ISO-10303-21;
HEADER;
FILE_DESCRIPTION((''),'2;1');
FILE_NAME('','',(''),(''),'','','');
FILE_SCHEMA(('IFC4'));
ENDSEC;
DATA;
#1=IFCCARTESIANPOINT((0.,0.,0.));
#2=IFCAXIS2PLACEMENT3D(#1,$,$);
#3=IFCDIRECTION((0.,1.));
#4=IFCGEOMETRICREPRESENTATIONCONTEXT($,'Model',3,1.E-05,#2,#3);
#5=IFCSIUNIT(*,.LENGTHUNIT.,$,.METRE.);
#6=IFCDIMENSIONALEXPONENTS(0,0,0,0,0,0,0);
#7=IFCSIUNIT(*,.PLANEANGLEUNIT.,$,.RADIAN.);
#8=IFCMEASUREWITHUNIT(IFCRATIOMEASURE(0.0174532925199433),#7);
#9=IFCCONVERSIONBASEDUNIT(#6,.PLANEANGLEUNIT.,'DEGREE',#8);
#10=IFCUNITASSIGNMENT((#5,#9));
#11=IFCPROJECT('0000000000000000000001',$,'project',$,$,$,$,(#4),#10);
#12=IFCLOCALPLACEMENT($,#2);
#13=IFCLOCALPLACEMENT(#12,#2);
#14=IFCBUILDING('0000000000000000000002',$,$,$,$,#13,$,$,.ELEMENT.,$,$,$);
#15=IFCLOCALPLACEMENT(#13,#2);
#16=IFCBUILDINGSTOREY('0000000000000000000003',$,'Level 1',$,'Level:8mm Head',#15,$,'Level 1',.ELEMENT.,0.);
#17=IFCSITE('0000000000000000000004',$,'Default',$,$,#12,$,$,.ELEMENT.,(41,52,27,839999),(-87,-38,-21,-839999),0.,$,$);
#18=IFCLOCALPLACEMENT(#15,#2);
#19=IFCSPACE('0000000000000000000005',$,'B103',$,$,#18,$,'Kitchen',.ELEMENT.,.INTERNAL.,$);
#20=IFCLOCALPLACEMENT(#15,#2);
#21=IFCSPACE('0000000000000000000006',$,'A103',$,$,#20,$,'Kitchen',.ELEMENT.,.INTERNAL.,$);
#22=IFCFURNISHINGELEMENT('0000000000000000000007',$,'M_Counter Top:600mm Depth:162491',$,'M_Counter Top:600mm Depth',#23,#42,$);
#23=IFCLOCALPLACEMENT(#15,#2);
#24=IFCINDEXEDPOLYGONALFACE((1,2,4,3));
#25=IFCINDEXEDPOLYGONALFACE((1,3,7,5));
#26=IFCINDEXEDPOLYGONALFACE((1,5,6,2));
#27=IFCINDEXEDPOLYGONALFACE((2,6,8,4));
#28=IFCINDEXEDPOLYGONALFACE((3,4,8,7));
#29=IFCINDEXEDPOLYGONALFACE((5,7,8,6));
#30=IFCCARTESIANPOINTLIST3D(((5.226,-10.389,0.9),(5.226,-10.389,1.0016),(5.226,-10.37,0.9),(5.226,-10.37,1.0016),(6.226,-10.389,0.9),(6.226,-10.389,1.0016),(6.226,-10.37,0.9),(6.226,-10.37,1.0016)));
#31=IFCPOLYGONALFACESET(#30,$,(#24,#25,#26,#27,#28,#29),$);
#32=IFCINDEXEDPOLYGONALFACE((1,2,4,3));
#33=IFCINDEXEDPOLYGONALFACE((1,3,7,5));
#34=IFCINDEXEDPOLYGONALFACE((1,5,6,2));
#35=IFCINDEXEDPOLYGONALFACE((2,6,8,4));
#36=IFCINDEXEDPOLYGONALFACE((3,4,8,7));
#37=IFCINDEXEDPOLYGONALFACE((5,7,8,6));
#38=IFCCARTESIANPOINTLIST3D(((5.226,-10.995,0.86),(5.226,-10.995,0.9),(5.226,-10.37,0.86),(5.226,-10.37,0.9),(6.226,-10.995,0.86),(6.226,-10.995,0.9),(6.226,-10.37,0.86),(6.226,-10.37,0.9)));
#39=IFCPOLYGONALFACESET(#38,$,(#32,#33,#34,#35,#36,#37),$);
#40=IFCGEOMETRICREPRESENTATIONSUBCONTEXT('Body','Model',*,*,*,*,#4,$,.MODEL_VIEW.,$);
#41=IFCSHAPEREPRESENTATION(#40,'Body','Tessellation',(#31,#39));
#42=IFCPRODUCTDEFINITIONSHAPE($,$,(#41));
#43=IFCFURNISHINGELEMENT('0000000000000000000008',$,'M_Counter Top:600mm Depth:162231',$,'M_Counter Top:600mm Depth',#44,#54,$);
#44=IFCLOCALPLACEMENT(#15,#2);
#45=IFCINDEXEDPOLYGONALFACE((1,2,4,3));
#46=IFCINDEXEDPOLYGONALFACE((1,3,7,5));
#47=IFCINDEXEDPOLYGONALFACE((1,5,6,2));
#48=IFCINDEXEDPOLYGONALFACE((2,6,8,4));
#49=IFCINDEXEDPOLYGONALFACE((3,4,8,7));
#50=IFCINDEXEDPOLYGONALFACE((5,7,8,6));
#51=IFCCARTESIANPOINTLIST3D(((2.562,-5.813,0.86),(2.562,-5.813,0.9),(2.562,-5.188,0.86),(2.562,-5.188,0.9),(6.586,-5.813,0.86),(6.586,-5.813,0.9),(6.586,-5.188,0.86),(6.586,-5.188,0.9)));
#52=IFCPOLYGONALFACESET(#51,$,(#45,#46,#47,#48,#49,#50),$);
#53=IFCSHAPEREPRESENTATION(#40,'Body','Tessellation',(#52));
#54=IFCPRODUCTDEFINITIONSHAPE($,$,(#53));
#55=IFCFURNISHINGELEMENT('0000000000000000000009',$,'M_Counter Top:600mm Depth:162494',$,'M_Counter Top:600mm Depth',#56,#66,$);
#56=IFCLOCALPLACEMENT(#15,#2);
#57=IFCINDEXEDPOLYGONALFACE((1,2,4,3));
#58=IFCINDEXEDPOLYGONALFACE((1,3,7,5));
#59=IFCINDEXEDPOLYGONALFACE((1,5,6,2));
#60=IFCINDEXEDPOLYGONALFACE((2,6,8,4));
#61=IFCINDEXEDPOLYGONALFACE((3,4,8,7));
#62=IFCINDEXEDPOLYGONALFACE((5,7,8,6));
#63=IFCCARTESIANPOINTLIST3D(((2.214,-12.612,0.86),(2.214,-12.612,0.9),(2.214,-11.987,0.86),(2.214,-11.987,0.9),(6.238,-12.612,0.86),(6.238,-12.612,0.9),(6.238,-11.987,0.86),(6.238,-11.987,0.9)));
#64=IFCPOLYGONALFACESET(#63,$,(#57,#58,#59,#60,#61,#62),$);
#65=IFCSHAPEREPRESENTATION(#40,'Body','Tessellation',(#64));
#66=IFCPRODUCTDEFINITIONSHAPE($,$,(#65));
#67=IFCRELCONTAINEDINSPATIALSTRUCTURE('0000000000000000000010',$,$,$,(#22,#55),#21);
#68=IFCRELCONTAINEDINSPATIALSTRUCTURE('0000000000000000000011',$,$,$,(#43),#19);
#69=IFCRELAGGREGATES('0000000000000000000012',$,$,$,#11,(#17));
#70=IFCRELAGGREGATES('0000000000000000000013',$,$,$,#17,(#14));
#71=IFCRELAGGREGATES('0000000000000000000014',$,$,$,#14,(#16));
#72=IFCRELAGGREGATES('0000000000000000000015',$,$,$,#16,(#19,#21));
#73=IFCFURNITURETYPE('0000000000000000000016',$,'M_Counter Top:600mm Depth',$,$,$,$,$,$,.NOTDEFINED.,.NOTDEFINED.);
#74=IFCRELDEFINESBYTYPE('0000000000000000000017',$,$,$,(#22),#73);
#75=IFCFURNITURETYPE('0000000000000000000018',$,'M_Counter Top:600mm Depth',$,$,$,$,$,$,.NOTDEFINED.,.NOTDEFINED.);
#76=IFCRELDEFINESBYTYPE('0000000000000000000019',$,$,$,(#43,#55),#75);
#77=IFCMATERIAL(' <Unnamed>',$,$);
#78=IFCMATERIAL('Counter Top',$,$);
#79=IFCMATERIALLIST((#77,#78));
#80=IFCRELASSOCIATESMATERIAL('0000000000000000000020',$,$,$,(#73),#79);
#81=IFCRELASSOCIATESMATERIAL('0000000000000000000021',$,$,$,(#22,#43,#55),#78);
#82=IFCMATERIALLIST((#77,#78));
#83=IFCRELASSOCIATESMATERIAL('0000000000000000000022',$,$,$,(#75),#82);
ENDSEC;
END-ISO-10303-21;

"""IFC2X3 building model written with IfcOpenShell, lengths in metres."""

from ifc_helpers import new_model, entity, si_unit, converted_unit, direction, frame, frame_2d, origin, place, context, subcontext, project, spatial, rectangle, extrude, source, transform, mapped, material, material_list, type_object, type_shapes, element, save


model = new_model("IFC2X3")

# Units and contexts
model_context = context("Model", 3, precision=1e-05, world=origin(), true_north=direction((0.0, 1.0)))
body_context = subcontext(model_context, "Body", "Model", "MODEL_VIEW")
ifc_project = project(units=[si_unit("LENGTHUNIT", "METRE"), converted_unit("PLANEANGLEUNIT", "DEGREE", entity("IfcRatioMeasure", 0.0174532925199433), si_unit("PLANEANGLEUNIT", "RADIAN"), dimensions=[0, 0, 0, 0, 0, 0, 0])], contexts=[model_context])

# Site, building, storey
site_placement = place(None, origin())
site = spatial("IfcSite", under=ifc_project, at=site_placement, Name="Default", CompositionType="ELEMENT", RefLatitude=(41, 52, 27, 839999), RefLongitude=(-87, -38, -21, -839999), RefElevation=0.0)
building_placement = place(site_placement, origin())
building = spatial("IfcBuilding", under=site, at=building_placement, CompositionType="ELEMENT")
storey_placement = place(building_placement, origin())
storey = spatial("IfcBuildingStorey", under=building, at=storey_placement, Name="Level 1", ObjectType="Level:8mm Head", LongName="Level 1", CompositionType="ELEMENT", Elevation=0.0)

# Shared definitions
space_1_placement = place(storey_placement, origin())
space_1 = spatial("IfcSpace", under=storey, at=space_1_placement, Name="B103", LongName="Kitchen", CompositionType="ELEMENT", InteriorOrExteriorSpace="INTERNAL")

# Shared definitions
ifc_material_1 = material(Name="Counter Top")
ifc_material_2 = material(Name=" <Unnamed>")

# Shared definitions
ifc_material_list_1 = material_list([ifc_material_2, ifc_material_1])
furniture_type_1 = type_object("IfcFurnitureType", Name="M_Counter Top:600mm Depth", material=ifc_material_list_1)
shared_shape_1 = source(origin(), body_context, "Body", "SweptSolid", [
    extrude(rectangle(XDim=0.0191, YDim=1.0, at=frame_2d((0.0, 0.0), x_axis=(1.0, 0.0))), frame((-0.7005, -0.0095, 0.9), z_axis=(0.0, 0.0, 1.0), x_axis=(0.0, -1.0, 0.0)), (0.0, 0.0, 1.0), 0.1016),
    extrude(rectangle(XDim=1.0, YDim=0.625, at=frame_2d((0.0, 0.0), x_axis=(1.0, 0.0))), frame((-0.7005, -0.3125, 0.86), z_axis=(0.0, 0.0, 1.0), x_axis=(-1.0, 0.0, 0.0)), (0.0, 0.0, 1.0), 0.04),
])
type_shapes(furniture_type_1, [shared_shape_1])

# Shared definitions
space_2_placement = place(storey_placement, origin())
space_2 = spatial("IfcSpace", under=storey, at=space_2_placement, Name="A103", LongName="Kitchen", CompositionType="ELEMENT", InteriorOrExteriorSpace="INTERNAL")

# Furnishing elements
furnishing_1_placement = place(space_2_placement, frame((6.4265, -10.37, 0.0)))
element("IfcFurnishingElement", 1, at=furnishing_1_placement, inside=space_2, type_object=furniture_type_1, material=ifc_material_1, Name="M_Counter Top:600mm Depth:162491", ObjectType="M_Counter Top:600mm Depth", context=body_context, shape_type="MappedRepresentation", body=[
    mapped(shared_shape_1, transform((0.0, 0.0, 0.0), scale=1.0)),
])
ifc_material_list_2 = material_list([ifc_material_2, ifc_material_1])
furniture_type_2 = type_object("IfcFurnitureType", Name="M_Counter Top:600mm Depth", material=ifc_material_list_2)
shared_shape_2 = source(origin(), body_context, "Body", "SweptSolid", [
    extrude(rectangle(XDim=4.024, YDim=0.625, at=frame_2d((0.0, 0.0), x_axis=(1.0, 0.0))), frame((0.8115, -0.3125, 0.86), z_axis=(0.0, 0.0, 1.0), x_axis=(-1.0, 0.0, 0.0)), (0.0, 0.0, 1.0), 0.04),
])
type_shapes(furniture_type_2, [shared_shape_2])
furnishing_2_placement = place(space_1_placement, frame((3.7625, -5.188, 0.0)))
element("IfcFurnishingElement", 2, at=furnishing_2_placement, inside=space_1, type_object=furniture_type_2, material=ifc_material_1, Name="M_Counter Top:600mm Depth:162231", ObjectType="M_Counter Top:600mm Depth", context=body_context, shape_type="MappedRepresentation", body=[
    mapped(shared_shape_2, transform((0.0, 0.0, 0.0), scale=1.0)),
])
furnishing_3_placement = place(space_2_placement, frame((5.0375, -12.612, 0.0), z_axis=(0.0, 0.0, 1.0), x_axis=(-1.0, 0.0, 0.0)))
element("IfcFurnishingElement", 3, at=furnishing_3_placement, inside=space_2, type_object=furniture_type_2, material=ifc_material_1, Name="M_Counter Top:600mm Depth:162494", ObjectType="M_Counter Top:600mm Depth", context=body_context, shape_type="MappedRepresentation", body=[
    mapped(shared_shape_2, transform((0.0, 0.0, 0.0), scale=1.0)),
])

save(model, "model.ifc")
